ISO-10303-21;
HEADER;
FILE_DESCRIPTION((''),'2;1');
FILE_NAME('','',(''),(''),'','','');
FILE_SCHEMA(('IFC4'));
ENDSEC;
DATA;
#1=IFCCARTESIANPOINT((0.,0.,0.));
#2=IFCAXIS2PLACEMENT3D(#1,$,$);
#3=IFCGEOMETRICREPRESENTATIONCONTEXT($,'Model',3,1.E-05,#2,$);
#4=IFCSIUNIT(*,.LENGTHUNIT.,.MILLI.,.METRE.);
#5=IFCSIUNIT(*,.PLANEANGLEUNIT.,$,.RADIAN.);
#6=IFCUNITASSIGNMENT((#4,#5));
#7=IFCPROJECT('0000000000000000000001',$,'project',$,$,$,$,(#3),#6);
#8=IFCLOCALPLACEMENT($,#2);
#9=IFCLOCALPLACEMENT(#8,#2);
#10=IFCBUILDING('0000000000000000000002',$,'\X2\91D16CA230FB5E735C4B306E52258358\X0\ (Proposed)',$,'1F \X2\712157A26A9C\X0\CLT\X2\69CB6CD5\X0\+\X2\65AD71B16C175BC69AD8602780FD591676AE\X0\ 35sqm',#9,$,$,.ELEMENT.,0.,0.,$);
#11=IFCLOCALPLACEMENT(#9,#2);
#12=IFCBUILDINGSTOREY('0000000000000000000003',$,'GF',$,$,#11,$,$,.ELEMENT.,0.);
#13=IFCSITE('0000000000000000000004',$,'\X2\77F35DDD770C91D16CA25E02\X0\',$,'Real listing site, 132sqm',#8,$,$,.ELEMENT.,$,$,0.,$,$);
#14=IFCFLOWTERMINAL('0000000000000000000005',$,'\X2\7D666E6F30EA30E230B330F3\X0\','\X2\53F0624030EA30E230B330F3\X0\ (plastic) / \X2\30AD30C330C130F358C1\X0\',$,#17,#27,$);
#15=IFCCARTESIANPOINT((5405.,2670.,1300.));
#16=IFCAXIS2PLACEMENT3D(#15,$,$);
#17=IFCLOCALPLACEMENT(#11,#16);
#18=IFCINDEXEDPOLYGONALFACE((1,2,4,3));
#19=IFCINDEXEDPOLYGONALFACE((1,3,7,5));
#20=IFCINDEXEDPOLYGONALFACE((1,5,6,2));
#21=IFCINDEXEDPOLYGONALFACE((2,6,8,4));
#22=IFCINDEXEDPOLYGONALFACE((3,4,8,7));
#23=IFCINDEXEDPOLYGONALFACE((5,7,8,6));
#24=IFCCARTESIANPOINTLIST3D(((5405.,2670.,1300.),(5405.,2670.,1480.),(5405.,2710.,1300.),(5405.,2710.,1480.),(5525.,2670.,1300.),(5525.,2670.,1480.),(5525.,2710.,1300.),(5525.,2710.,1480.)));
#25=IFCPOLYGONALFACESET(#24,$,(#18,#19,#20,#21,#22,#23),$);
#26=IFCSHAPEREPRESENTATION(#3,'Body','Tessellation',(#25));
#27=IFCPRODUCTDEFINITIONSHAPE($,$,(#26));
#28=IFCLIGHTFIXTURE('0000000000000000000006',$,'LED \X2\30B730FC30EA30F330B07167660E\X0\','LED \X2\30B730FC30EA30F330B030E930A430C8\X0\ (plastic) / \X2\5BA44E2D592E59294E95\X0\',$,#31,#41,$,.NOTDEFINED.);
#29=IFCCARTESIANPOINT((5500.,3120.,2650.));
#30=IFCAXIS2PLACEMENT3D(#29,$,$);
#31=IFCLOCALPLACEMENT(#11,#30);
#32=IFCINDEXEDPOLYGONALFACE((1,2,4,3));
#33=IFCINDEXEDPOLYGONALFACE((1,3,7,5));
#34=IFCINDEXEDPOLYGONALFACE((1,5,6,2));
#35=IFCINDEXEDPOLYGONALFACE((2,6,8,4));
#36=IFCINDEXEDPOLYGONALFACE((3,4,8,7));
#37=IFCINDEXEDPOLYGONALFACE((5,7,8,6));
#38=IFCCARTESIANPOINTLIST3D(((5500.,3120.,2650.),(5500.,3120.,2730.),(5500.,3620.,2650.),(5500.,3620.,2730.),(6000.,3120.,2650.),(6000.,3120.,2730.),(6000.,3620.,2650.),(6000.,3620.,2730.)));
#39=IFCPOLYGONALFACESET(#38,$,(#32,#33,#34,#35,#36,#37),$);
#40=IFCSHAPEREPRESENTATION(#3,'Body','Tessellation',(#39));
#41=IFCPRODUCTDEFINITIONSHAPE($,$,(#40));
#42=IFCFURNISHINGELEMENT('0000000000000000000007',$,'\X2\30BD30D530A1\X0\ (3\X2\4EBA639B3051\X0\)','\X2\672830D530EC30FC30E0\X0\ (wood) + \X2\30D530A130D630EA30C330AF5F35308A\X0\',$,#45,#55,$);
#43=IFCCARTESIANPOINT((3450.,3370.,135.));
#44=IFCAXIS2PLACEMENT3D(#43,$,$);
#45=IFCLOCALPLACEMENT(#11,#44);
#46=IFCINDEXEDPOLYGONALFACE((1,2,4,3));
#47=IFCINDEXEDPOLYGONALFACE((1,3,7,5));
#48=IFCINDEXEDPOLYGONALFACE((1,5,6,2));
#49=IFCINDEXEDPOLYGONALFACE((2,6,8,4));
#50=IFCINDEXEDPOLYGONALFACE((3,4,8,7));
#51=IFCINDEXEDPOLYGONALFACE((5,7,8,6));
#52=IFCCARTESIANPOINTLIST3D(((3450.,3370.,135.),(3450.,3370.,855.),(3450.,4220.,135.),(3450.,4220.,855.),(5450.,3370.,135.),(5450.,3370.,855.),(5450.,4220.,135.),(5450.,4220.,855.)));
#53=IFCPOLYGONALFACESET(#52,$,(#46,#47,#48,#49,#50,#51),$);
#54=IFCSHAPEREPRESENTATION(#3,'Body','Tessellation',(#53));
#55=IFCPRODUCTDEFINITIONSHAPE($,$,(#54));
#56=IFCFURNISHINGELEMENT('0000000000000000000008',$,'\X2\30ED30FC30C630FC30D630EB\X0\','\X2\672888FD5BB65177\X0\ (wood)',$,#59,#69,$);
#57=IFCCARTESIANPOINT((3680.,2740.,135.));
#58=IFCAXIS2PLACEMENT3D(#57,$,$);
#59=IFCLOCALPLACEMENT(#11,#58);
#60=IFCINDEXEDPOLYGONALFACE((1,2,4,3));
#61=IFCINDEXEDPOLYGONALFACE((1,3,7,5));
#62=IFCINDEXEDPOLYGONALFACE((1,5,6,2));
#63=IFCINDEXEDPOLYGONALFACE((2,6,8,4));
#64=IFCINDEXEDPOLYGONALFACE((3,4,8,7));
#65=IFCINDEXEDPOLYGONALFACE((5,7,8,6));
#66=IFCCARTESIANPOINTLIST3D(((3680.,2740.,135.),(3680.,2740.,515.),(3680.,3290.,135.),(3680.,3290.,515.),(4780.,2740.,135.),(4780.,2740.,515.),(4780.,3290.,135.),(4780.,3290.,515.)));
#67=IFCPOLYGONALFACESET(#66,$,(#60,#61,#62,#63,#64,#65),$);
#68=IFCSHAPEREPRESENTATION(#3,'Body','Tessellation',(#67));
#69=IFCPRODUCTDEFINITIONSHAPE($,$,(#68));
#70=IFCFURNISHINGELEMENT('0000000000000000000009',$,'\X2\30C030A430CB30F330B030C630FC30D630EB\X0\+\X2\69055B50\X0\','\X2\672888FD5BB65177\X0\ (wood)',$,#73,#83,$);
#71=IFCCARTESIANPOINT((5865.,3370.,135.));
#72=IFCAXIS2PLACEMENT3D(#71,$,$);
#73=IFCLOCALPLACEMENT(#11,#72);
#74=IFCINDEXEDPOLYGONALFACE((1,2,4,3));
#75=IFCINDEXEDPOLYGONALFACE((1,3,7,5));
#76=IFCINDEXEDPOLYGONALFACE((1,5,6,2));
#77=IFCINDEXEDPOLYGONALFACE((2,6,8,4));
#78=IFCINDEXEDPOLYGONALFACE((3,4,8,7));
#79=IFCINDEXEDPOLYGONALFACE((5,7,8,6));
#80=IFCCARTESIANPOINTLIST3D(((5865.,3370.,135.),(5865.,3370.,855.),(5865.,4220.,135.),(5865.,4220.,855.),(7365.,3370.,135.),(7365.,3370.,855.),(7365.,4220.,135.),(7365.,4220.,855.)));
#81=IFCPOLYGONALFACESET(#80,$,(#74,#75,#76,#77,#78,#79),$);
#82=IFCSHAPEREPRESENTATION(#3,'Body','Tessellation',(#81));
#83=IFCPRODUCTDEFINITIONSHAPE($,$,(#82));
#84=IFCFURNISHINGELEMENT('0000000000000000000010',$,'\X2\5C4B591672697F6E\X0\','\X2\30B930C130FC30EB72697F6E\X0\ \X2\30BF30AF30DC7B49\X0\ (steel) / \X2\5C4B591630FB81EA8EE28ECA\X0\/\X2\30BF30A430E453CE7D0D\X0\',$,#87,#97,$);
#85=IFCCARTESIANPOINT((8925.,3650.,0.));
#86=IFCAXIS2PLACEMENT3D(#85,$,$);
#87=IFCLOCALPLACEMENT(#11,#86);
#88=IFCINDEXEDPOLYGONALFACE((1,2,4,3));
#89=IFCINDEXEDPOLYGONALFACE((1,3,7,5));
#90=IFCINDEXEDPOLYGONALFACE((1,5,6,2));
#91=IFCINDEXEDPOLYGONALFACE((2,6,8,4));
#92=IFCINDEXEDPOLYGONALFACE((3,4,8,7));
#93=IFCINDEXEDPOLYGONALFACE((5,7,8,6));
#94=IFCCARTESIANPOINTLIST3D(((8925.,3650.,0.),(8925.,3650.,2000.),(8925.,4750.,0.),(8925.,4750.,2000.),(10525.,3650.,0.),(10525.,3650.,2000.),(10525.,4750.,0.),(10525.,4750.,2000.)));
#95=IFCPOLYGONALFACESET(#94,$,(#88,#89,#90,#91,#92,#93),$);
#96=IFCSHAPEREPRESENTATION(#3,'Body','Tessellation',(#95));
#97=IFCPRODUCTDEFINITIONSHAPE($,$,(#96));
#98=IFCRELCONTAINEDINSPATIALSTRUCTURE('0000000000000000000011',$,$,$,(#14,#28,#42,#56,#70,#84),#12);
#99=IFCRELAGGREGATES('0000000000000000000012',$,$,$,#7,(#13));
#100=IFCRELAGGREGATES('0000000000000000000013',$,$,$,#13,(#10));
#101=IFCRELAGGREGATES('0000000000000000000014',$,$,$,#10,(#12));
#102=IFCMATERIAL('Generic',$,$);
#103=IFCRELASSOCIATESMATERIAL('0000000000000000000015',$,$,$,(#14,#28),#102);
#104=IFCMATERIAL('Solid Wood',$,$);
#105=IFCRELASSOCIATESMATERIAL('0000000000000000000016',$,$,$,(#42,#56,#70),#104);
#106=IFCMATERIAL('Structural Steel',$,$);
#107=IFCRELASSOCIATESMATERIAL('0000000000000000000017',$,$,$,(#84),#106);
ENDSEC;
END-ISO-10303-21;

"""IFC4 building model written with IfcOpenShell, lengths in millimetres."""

from ifc_helpers import new_model, si_unit, frame, frame_2d, origin, place, context, project, spatial, rectangle, extrude, material, element, save


model = new_model("IFC4")

# Units and contexts
model_context = context("Model", 3, precision=1e-05, world=origin())
ifc_project = project(units=[si_unit("LENGTHUNIT", "METRE", prefix="MILLI"), si_unit("PLANEANGLEUNIT", "RADIAN")], contexts=[model_context])

# Site, building, storey
site_placement = place(None, origin())
site = spatial("IfcSite", under=ifc_project, at=site_placement, Name="石川県金沢市", ObjectType="Real listing site, 132sqm", CompositionType="ELEMENT", RefElevation=0.0)
building_placement = place(site_placement, origin())
building = spatial("IfcBuilding", under=site, at=building_placement, Name="金沢・平屋の別荘 (Proposed)", ObjectType="1F 無垢檜CLT構法+断熱気密高性能外皮 35sqm", CompositionType="ELEMENT", ElevationOfRefHeight=0.0, ElevationOfTerrain=0.0)
storey_placement = place(building_placement, origin())
storey = spatial("IfcBuildingStorey", under=building, at=storey_placement, Name="GF", CompositionType="ELEMENT", Elevation=0.0)

# Shared definitions
ifc_material_1 = material(Name="Solid Wood")

# Shared definitions
ifc_material_2 = material(Name="Structural Steel")

# Flow terminal
ifc_material_3 = material(Name="Generic")
flow_terminal_placement = place(storey_placement, frame((5405.0, 2670.0, 1300.0)))
element("IfcFlowTerminal", 1, at=flow_terminal_placement, inside=storey, material=ifc_material_3, Name="給湯リモコン", Description="台所リモコン (plastic) / キッチン壁", context=model_context, shape_type="SweptSolid", body=[
    extrude(rectangle(XDim=120.0, YDim=40.0, at=frame_2d((60.0, 20.0))), frame((5405.0, 2670.0, 1300.0)), (0.0, 0.0, 1.0), 180.0),
])

# Light fixture
light_fixture_placement = place(storey_placement, frame((5500.0, 3120.0, 2650.0)))
element("IfcLightFixture", 2, at=light_fixture_placement, inside=storey, material=ifc_material_3, Name="LED シーリング照明", Description="LED シーリングライト (plastic) / 室中央天井", PredefinedType="NOTDEFINED", context=model_context, shape_type="SweptSolid", body=[
    extrude(rectangle(XDim=500.0, YDim=500.0, at=frame_2d((250.0, 250.0))), frame((5500.0, 3120.0, 2650.0)), (0.0, 0.0, 1.0), 80.0),
])

# Furnishing elements
furnishing_1_placement = place(storey_placement, frame((3450.0, 3370.0, 135.0)))
element("IfcFurnishingElement", 3, at=furnishing_1_placement, inside=storey, material=ifc_material_1, Name="ソファ (3人掛け)", Description="木フレーム (wood) + ファブリック張り", context=model_context, shape_type="SweptSolid", body=[
    extrude(rectangle(XDim=2000.0, YDim=850.0, at=frame_2d((1000.0, 425.0))), frame((3450.0, 3370.0, 135.0)), (0.0, 0.0, 1.0), 720.0),
])
furnishing_2_placement = place(storey_placement, frame((3680.0, 2740.0, 135.0)))
element("IfcFurnishingElement", 4, at=furnishing_2_placement, inside=storey, material=ifc_material_1, Name="ローテーブル", Description="木製家具 (wood)", context=model_context, shape_type="SweptSolid", body=[
    extrude(rectangle(XDim=1100.0, YDim=550.0, at=frame_2d((550.0, 275.0))), frame((3680.0, 2740.0, 135.0)), (0.0, 0.0, 1.0), 380.0),
])
furnishing_3_placement = place(storey_placement, frame((5865.0, 3370.0, 135.0)))
element("IfcFurnishingElement", 5, at=furnishing_3_placement, inside=storey, material=ifc_material_1, Name="ダイニングテーブル+椅子", Description="木製家具 (wood)", context=model_context, shape_type="SweptSolid", body=[
    extrude(rectangle(XDim=1500.0, YDim=850.0, at=frame_2d((750.0, 425.0))), frame((5865.0, 3370.0, 135.0)), (0.0, 0.0, 1.0), 720.0),
])
furnishing_4_placement = place(storey_placement, frame((8925.0, 3650.0, 0.0)))
element("IfcFurnishingElement", 6, at=furnishing_4_placement, inside=storey, material=ifc_material_2, Name="屋外物置", Description="スチール物置 タクボ等 (steel) / 屋外・自転車/タイヤ収納", context=model_context, shape_type="SweptSolid", body=[
    extrude(rectangle(XDim=1600.0, YDim=1100.0, at=frame_2d((800.0, 550.0))), frame((8925.0, 3650.0, 0.0)), (0.0, 0.0, 1.0), 2000.0),
])

save(model, "model.ifc")
